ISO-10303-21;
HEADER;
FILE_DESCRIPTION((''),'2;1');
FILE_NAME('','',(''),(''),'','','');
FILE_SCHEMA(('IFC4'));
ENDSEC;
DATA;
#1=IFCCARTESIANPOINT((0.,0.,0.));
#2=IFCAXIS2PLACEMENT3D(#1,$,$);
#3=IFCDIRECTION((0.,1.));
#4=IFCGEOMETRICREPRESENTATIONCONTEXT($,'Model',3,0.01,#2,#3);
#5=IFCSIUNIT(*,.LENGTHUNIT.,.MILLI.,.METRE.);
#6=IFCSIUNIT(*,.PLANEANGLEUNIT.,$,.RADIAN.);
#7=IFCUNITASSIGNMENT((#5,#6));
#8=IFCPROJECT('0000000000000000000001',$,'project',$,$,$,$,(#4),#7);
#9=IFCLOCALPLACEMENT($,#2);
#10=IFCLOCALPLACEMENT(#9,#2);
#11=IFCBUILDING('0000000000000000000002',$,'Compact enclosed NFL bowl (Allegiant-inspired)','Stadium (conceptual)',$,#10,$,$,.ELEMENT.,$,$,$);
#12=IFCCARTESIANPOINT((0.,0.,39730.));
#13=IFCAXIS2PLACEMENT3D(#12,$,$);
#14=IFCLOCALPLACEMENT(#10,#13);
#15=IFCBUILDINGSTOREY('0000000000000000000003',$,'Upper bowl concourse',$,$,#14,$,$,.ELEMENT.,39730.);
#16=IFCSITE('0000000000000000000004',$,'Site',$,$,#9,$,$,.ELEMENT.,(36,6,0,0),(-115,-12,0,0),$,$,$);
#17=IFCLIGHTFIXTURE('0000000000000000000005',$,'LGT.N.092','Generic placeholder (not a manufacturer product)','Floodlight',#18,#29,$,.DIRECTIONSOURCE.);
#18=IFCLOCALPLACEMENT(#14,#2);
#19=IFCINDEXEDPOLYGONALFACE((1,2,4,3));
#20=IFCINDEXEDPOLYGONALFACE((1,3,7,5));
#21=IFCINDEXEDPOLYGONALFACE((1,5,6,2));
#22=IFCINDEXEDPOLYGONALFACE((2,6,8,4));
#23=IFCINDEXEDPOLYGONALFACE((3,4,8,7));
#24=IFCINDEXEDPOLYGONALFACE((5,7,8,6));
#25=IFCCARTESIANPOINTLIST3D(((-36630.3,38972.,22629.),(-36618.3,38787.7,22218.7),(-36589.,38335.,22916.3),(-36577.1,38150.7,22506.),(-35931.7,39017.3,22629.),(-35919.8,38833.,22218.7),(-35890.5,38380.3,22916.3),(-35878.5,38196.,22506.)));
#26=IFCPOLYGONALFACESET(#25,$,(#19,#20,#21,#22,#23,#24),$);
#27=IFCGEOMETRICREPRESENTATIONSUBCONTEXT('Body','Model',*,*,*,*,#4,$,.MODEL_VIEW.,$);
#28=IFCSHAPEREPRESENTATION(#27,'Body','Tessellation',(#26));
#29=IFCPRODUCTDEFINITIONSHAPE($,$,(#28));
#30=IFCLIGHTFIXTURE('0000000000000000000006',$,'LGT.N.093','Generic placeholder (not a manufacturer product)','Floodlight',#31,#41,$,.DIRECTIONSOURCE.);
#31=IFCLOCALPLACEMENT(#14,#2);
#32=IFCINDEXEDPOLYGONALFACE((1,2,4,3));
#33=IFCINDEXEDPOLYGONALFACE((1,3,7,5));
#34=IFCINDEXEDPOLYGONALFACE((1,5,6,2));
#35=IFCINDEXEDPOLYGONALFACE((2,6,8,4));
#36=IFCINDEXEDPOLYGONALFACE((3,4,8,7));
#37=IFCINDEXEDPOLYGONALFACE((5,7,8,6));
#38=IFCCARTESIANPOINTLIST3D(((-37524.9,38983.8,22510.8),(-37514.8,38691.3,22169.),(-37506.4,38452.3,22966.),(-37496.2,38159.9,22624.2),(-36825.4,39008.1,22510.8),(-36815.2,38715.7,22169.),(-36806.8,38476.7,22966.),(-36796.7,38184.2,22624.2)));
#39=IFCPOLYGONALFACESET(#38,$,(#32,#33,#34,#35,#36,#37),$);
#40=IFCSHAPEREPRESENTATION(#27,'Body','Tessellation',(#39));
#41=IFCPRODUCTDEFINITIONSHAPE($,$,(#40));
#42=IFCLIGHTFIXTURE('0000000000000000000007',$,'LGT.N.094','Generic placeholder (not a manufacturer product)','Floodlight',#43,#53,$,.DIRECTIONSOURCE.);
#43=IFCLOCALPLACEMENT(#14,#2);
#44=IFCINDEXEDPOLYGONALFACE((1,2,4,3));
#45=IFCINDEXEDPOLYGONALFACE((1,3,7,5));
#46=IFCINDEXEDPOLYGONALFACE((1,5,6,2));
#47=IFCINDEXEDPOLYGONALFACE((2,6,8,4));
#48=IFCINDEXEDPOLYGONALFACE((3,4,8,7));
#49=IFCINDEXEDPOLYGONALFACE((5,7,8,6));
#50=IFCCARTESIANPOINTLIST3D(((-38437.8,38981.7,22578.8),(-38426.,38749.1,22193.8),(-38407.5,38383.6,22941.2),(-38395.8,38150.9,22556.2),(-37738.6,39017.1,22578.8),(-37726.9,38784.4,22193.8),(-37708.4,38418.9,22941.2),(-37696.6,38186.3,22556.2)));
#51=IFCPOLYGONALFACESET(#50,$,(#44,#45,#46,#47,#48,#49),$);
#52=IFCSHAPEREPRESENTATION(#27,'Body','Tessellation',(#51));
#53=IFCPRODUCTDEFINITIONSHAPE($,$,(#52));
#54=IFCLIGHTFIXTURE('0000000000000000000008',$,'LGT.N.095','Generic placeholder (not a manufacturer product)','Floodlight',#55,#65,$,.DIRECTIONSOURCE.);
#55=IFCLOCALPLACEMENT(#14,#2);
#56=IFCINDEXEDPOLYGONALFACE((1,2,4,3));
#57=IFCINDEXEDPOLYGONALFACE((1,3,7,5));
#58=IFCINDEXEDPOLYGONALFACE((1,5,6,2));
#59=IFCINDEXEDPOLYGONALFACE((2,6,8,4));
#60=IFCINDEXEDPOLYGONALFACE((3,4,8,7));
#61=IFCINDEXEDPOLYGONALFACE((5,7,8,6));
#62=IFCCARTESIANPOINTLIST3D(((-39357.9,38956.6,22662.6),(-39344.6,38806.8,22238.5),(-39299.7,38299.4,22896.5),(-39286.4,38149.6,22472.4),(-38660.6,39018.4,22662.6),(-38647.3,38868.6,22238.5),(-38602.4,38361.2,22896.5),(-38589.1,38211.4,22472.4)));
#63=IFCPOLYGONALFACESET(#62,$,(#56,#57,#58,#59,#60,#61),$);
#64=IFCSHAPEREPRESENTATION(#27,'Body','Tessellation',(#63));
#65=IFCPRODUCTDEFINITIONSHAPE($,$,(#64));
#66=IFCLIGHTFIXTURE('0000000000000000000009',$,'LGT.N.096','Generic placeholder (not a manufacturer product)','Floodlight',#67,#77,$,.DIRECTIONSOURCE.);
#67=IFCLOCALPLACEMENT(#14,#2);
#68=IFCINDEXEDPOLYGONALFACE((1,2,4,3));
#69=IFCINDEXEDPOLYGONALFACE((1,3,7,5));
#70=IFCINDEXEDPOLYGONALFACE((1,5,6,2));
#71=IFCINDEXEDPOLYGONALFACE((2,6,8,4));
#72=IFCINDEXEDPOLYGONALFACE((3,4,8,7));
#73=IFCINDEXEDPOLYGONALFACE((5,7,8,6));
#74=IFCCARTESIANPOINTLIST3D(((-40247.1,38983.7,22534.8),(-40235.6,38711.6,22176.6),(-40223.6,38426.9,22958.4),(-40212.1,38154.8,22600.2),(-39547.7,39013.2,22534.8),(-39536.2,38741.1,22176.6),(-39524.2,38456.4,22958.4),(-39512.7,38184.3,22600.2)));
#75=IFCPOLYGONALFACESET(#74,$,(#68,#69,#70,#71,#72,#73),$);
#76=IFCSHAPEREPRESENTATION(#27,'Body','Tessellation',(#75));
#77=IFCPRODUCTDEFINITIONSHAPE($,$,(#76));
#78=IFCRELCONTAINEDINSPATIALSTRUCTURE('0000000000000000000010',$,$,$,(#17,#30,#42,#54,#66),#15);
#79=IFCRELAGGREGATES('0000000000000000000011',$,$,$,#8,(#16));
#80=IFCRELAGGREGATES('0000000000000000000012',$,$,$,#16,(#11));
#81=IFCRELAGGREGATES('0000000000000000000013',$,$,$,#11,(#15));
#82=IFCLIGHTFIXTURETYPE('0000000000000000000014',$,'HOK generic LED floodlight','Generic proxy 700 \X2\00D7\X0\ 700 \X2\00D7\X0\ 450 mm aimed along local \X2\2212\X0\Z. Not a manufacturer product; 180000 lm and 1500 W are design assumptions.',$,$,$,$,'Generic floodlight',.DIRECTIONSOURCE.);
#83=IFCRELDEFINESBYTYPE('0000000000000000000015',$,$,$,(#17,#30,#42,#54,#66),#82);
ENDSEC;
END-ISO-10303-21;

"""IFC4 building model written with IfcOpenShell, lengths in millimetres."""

from ifc_helpers import new_model, si_unit, direction, frame, origin, place, context, subcontext, project, spatial, rectangle, extrude, source, transform, mapped, type_object, type_shapes, element, save


model = new_model("IFC4")

# Units and contexts
model_context = context("Model", 3, precision=0.01, world=origin(), true_north=direction((0.0, 1.0)))
body_context = subcontext(model_context, "Body", "Model", "MODEL_VIEW")
ifc_project = project(units=[si_unit("LENGTHUNIT", "METRE", prefix="MILLI"), si_unit("PLANEANGLEUNIT", "RADIAN")], contexts=[model_context])

# Site, building, storey
site_placement = place(None, origin())
site = spatial("IfcSite", under=ifc_project, at=site_placement, Name="Site", CompositionType="ELEMENT", RefLatitude=(36, 6, 0, 0), RefLongitude=(-115, -12, 0, 0))
building_placement = place(site_placement, origin())
building = spatial("IfcBuilding", under=site, at=building_placement, Name="Compact enclosed NFL bowl (Allegiant-inspired)", Description="Stadium (conceptual)", CompositionType="ELEMENT")
storey_placement = place(building_placement, frame((0.0, 0.0, 39730.0)))
storey = spatial("IfcBuildingStorey", under=building, at=storey_placement, Name="Upper bowl concourse", CompositionType="ELEMENT", Elevation=39730.0)

# Light fixtures
light_fixture_type = type_object("IfcLightFixtureType", Name="HOK generic LED floodlight", Description="Generic proxy 700 × 700 × 450 mm aimed along local −Z. Not a manufacturer product; 180000 lm and 1500 W are design assumptions.", ElementType="Generic floodlight", PredefinedType="DIRECTIONSOURCE")
shared_shape = source(origin(), body_context, "Body", "SweptSolid", [
    extrude(rectangle(XDim=700.0, YDim=700.0), frame((0.0, 0.0, -225.0)), (0.0, 0.0, 1.0), 450.0),
])
type_shapes(light_fixture_type, [shared_shape])
for number, where, z_axis, x_axis, name in (
    (1, (-36254.4, 38584.0, 22567.5), (-0.026535, 0.409538, 0.911907), (-0.997908, -0.064656, 0.0), "LGT.N.092"),
    (2, (-37160.8, 38584.0, 22567.5), (-0.022658, 0.649906, 0.759677), (-0.999393, -0.034842, 0.0), "LGT.N.093"),
    (3, (-38067.2, 38584.0, 22567.5), (-0.02614, 0.517043, 0.85556), (-0.998724, -0.050492, 0.0), "LGT.N.094"),
    (4, (-38973.5, 38584.0, 22567.5), (-0.029482, 0.332861, 0.942515), (-0.9961, -0.088226, 0.0), "LGT.N.095"),
    (5, (-39879.9, 38584.0, 22567.5), (-0.02548, 0.604667, 0.796071), (-0.999113, -0.042102, 0.0), "LGT.N.096"),
):
    element("IfcLightFixture", number, at=place(storey_placement, frame(where, z_axis=z_axis, x_axis=x_axis)), inside=storey, type_object=light_fixture_type, Name=name, Description="Generic placeholder (not a manufacturer product)", ObjectType="Floodlight", PredefinedType="DIRECTIONSOURCE", context=body_context, shape_type="MappedRepresentation", body=[
        mapped(shared_shape, transform((0.0, 0.0, 0.0))),
    ])

save(model, "model.ifc")
